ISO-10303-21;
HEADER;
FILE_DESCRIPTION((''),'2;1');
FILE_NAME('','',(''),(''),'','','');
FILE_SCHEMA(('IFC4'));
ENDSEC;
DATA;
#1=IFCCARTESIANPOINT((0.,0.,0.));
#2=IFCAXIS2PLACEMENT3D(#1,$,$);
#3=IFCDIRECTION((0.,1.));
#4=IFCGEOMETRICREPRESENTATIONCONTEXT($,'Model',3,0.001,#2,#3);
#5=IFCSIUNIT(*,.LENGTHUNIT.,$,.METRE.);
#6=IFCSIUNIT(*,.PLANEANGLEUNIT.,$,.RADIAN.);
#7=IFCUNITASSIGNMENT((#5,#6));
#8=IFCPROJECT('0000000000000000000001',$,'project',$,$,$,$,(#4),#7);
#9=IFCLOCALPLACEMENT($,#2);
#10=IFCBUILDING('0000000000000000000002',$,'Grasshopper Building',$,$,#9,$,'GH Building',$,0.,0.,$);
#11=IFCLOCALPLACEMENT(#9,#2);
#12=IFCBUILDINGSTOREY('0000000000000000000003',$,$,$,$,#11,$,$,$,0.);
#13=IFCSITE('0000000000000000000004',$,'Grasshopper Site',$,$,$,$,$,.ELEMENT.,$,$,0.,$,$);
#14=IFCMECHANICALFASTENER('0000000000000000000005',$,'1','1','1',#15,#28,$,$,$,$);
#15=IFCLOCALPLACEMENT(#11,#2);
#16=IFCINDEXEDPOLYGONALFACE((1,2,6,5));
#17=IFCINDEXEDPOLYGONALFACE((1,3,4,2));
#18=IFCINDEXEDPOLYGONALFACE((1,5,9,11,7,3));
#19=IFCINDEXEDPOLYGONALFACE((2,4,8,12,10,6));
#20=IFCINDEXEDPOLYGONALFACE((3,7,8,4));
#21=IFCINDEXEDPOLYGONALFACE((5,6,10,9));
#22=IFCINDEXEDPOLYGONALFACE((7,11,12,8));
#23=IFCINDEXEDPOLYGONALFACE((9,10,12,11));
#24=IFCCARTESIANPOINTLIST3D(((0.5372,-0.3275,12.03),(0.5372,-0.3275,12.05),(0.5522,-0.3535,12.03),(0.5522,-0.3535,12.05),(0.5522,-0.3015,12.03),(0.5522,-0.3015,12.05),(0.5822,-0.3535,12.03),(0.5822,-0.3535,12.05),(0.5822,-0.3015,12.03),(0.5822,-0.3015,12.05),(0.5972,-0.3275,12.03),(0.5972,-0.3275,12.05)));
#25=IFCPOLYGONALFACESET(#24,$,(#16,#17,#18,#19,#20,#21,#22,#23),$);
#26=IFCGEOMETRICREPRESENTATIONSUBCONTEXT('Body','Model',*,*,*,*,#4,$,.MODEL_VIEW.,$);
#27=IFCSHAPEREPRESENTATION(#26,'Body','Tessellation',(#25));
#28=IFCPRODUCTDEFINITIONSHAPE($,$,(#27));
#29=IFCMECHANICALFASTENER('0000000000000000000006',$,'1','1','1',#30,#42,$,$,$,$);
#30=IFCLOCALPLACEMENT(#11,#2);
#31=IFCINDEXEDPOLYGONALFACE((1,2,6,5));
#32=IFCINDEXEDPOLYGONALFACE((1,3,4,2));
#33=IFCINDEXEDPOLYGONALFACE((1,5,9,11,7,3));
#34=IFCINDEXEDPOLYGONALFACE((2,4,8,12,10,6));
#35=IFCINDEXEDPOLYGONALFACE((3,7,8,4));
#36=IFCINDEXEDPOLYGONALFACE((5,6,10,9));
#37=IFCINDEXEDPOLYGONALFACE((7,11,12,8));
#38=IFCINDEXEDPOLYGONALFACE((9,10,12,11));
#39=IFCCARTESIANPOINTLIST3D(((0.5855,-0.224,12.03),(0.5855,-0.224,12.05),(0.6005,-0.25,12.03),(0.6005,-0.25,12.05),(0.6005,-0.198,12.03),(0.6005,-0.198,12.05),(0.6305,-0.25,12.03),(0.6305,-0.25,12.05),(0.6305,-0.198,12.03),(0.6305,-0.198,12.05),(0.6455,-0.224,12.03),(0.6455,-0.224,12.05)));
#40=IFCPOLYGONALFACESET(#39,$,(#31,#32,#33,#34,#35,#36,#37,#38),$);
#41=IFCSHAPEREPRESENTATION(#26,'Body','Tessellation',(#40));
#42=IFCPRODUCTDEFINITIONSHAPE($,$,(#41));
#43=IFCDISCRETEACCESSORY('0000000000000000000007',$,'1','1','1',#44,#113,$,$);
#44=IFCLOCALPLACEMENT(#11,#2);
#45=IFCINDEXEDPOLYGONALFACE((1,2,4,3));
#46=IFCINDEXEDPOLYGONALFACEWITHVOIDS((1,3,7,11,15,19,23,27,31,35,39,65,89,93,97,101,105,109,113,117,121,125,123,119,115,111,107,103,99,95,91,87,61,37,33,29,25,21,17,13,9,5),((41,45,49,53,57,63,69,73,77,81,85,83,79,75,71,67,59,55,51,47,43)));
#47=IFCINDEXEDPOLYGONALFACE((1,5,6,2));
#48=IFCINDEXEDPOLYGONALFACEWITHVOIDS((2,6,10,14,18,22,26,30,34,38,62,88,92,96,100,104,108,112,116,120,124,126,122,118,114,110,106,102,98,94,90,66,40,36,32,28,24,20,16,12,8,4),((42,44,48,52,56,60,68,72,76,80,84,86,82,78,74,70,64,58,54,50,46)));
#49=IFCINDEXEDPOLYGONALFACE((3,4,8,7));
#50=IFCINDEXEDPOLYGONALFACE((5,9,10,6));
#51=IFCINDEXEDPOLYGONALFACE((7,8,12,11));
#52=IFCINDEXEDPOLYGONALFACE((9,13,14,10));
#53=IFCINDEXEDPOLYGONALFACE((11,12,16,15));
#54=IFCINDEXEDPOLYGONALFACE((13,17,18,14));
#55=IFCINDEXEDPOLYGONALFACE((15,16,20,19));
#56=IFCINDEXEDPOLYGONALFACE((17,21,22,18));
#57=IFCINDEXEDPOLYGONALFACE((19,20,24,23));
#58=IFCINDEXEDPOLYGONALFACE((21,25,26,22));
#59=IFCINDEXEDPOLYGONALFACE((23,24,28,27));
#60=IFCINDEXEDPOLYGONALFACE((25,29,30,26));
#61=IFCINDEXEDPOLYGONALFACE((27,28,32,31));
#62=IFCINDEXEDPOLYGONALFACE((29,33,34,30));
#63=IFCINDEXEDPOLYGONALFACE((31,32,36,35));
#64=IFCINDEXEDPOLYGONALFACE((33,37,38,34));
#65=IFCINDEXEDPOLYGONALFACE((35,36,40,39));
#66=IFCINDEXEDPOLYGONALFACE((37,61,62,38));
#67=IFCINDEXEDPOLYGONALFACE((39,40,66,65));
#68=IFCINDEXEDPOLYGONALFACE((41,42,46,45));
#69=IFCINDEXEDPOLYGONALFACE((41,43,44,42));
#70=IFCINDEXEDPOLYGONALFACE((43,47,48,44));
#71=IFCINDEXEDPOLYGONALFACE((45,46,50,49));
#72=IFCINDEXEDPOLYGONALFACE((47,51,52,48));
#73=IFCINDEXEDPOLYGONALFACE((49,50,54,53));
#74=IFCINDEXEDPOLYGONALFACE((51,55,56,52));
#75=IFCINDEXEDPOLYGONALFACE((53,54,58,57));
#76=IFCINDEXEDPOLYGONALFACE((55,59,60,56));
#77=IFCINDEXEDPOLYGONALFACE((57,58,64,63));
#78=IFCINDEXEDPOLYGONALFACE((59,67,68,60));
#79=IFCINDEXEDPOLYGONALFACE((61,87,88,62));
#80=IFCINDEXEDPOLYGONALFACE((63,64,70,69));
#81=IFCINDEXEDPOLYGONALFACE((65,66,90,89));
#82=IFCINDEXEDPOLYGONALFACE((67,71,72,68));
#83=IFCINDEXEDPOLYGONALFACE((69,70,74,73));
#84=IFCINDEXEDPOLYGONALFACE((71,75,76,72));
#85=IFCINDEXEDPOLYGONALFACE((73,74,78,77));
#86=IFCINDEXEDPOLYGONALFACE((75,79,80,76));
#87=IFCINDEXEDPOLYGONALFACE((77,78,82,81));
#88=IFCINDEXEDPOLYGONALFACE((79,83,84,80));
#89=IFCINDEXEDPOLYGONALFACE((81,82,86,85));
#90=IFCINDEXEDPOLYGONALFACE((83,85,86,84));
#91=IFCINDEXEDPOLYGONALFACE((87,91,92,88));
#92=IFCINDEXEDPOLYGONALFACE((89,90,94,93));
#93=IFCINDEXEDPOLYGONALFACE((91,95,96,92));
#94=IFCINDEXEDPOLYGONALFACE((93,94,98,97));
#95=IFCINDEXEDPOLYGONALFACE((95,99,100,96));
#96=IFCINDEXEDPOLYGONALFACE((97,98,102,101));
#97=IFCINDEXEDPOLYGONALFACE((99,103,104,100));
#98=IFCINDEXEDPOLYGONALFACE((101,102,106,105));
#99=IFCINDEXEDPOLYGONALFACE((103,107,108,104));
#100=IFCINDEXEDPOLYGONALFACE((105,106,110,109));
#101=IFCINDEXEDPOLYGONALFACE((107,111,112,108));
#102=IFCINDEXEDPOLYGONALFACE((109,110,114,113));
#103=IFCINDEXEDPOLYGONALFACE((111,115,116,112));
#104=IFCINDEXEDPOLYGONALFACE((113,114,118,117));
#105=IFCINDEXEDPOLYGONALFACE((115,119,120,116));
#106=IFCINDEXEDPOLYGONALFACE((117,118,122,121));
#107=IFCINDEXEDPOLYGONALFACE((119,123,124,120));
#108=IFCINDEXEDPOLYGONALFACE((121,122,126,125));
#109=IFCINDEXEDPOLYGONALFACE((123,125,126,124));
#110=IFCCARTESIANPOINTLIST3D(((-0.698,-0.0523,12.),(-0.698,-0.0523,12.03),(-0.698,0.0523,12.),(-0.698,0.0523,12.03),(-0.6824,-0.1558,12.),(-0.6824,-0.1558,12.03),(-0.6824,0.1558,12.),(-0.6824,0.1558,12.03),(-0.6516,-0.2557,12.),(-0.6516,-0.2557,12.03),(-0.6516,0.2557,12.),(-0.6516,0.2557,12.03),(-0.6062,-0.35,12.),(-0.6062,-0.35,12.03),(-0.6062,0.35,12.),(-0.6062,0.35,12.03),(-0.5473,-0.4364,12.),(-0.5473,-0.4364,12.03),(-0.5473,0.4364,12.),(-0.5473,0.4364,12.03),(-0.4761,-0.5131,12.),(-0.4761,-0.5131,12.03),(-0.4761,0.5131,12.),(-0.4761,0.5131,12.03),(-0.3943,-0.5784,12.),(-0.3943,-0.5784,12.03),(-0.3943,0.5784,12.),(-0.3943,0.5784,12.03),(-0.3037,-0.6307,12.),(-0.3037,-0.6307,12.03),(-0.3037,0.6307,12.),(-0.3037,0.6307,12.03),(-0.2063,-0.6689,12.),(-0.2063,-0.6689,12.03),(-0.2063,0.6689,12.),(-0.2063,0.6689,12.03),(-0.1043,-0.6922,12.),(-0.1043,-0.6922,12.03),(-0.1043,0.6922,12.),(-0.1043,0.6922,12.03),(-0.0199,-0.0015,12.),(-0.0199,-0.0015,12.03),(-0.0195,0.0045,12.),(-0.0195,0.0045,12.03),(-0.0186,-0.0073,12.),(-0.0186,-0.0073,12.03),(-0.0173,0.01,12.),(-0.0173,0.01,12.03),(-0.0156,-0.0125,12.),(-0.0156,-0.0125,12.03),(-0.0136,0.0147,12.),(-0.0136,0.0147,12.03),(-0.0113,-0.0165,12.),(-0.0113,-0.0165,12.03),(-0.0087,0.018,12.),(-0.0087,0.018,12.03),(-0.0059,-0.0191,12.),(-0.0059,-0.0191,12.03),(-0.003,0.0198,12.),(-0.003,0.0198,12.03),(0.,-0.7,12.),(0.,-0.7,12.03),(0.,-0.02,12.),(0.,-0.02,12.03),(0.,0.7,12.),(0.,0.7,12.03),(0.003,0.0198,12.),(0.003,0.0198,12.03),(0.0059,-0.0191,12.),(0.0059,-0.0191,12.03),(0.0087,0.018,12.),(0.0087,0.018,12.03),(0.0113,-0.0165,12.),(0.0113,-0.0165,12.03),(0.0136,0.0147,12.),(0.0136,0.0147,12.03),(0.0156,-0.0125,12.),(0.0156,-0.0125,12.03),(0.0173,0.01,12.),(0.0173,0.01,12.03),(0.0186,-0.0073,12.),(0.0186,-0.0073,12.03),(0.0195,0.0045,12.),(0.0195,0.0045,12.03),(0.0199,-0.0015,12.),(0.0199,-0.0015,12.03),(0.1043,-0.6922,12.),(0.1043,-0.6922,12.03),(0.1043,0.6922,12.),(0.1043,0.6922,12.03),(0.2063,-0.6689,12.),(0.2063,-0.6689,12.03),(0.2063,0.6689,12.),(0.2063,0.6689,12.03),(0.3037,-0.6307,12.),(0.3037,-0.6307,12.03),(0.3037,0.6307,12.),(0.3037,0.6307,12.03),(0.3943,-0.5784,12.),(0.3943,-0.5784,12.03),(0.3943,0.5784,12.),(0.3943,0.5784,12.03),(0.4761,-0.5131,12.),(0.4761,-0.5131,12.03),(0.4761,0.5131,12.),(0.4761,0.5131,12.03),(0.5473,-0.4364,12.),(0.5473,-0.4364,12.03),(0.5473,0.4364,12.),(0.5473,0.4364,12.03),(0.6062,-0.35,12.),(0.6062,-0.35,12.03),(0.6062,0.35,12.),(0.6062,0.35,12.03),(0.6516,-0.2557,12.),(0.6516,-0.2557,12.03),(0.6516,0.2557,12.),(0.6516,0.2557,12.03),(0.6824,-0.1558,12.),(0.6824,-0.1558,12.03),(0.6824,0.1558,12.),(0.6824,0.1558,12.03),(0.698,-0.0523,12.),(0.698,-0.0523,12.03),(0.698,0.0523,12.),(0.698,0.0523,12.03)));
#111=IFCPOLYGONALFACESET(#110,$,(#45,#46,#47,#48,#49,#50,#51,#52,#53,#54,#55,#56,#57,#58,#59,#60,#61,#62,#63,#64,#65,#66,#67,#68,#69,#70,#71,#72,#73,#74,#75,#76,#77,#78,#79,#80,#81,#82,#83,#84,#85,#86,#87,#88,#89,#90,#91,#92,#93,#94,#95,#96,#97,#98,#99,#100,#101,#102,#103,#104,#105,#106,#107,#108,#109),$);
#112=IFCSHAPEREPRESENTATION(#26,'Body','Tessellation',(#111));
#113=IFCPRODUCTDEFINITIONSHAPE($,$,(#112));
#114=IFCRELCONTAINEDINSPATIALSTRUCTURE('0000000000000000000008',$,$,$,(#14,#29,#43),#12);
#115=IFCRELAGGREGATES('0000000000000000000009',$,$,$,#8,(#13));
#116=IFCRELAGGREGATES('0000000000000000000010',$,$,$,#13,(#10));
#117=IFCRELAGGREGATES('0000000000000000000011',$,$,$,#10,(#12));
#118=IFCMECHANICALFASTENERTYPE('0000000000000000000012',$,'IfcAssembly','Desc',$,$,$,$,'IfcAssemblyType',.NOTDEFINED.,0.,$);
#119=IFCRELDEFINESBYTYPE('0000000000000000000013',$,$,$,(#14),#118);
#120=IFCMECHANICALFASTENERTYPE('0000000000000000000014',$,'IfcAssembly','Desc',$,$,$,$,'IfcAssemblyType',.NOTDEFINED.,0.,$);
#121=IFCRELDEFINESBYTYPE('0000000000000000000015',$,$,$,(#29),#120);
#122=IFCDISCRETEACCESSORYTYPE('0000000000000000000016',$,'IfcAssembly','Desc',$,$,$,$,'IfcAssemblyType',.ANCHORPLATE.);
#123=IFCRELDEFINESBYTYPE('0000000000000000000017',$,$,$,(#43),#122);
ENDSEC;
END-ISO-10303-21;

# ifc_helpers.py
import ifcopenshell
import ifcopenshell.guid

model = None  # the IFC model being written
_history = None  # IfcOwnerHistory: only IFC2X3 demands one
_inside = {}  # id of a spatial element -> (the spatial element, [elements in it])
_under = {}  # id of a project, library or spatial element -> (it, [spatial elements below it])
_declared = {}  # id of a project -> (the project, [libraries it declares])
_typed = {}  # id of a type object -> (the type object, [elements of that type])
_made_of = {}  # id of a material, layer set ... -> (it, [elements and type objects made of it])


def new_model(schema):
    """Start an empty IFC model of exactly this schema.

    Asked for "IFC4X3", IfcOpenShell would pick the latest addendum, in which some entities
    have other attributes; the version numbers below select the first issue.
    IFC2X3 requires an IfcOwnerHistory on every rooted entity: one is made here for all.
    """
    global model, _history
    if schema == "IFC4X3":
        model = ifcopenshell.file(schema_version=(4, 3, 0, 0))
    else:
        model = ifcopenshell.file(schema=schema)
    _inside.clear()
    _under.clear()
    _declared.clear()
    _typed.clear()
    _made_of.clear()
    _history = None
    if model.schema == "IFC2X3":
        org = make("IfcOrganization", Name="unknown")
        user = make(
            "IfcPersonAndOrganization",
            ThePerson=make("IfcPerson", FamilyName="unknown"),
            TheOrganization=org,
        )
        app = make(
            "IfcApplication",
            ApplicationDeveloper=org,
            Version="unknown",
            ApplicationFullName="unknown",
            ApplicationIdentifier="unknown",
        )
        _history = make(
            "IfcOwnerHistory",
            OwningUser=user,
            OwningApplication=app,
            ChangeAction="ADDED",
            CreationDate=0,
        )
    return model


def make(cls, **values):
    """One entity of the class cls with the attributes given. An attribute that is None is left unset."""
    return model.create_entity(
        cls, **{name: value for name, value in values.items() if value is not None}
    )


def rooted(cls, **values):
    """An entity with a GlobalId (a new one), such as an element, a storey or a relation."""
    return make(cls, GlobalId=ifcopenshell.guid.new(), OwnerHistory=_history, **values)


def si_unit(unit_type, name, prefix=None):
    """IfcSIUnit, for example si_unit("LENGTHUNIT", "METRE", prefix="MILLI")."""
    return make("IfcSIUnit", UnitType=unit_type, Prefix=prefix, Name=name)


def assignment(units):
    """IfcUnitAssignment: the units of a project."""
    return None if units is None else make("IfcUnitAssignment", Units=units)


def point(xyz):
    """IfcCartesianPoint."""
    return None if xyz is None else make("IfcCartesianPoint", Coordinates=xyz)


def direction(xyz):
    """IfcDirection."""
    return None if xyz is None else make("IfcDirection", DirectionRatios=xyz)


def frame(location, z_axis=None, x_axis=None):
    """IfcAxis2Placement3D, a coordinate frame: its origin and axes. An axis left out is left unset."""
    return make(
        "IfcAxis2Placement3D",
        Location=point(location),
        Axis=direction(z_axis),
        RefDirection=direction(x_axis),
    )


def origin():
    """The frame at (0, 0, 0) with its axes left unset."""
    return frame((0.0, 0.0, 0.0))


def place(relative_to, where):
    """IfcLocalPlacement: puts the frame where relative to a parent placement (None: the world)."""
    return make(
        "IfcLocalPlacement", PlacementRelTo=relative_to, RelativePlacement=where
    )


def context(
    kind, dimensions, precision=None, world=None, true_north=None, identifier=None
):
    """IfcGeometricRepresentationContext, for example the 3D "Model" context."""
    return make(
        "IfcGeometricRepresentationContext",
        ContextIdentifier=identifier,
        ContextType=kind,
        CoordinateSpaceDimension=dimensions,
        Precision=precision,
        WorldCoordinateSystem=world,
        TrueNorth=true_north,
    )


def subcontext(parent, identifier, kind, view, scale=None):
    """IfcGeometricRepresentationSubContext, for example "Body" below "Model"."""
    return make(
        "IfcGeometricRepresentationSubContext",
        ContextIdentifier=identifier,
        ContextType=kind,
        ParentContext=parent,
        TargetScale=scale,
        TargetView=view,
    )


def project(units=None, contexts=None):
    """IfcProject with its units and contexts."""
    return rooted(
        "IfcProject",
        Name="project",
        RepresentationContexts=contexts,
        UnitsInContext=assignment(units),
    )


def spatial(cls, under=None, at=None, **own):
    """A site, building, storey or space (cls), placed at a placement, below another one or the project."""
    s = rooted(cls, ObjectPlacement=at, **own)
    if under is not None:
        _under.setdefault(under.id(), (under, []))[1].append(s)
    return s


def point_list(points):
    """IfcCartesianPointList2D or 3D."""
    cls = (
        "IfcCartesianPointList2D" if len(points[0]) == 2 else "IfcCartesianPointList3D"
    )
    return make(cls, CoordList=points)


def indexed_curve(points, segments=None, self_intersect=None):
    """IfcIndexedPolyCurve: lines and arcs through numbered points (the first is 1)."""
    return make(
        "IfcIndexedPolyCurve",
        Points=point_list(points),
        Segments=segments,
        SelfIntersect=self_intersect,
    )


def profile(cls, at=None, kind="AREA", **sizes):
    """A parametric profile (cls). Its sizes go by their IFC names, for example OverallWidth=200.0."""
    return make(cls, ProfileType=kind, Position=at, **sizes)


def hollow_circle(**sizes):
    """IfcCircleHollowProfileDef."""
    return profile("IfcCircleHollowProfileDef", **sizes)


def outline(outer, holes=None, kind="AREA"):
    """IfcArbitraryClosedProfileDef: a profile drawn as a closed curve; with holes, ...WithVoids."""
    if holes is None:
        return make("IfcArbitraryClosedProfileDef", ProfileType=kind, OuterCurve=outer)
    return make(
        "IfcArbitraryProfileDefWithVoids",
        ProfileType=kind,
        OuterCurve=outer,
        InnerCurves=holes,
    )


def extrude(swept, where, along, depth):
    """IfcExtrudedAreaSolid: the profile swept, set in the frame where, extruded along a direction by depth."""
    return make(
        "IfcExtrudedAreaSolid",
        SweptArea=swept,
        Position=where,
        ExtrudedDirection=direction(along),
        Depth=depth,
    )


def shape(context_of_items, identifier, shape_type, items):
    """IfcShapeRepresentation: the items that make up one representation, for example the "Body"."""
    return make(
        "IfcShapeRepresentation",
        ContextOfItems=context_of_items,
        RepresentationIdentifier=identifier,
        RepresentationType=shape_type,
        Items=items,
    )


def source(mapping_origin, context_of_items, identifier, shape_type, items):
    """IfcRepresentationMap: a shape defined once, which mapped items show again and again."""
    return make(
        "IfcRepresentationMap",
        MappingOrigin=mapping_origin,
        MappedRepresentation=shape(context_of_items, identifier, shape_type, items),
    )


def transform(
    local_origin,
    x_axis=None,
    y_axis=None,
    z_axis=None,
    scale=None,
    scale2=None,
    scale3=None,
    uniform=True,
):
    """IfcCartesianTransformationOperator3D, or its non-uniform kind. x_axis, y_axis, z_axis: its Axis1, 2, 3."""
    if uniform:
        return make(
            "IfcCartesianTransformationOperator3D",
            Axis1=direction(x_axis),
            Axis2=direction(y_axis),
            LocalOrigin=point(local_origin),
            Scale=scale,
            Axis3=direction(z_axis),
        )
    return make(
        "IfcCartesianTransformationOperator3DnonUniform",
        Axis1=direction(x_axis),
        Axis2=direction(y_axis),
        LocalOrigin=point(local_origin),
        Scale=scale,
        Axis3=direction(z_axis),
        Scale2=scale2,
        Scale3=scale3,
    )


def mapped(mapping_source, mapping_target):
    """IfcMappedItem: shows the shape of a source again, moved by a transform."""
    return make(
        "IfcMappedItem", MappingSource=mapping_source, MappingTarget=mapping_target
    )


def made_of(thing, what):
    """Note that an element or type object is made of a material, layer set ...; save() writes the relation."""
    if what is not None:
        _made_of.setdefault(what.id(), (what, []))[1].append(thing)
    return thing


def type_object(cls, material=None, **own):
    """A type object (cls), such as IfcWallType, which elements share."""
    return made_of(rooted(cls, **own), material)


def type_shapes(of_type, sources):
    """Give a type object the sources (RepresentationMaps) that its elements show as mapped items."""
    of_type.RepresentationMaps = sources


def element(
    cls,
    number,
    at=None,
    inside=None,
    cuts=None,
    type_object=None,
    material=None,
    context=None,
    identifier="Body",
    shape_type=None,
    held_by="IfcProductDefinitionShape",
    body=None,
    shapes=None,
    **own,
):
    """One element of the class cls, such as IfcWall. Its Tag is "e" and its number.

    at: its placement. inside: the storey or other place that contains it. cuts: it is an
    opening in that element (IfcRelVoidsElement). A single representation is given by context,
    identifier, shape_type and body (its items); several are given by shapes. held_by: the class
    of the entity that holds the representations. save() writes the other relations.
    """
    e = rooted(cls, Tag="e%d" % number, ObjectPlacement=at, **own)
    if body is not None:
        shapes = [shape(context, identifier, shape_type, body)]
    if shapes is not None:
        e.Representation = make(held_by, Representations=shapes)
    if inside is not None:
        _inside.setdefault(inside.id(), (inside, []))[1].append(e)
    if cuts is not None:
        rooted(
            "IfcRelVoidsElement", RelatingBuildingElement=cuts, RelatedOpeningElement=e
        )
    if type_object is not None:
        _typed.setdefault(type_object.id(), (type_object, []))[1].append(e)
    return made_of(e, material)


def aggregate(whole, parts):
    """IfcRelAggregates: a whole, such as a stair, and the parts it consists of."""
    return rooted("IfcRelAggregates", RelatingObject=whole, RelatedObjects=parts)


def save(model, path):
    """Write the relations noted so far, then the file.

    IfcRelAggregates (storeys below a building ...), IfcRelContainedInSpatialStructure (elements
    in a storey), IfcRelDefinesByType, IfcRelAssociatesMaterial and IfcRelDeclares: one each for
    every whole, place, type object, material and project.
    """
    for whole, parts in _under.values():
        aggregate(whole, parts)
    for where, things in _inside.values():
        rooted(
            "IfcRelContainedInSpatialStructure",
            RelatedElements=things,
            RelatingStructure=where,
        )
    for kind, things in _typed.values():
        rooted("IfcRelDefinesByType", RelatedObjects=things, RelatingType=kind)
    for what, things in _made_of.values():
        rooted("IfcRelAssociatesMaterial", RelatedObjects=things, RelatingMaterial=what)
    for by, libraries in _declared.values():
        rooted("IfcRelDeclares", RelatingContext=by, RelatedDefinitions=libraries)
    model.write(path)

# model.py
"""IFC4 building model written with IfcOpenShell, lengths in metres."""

from ifc_helpers import new_model, si_unit, direction, frame, origin, place, context, subcontext, project, spatial, indexed_curve, hollow_circle, outline, extrude, source, transform, mapped, type_object, type_shapes, element, save


model = new_model("IFC4")

# Units and contexts
model_context = context("Model", 3, precision=0.001, world=origin(), true_north=direction((0.0, 1.0)))
body_context = subcontext(model_context, "Body", "Model", "MODEL_VIEW")
ifc_project = project(units=[si_unit("LENGTHUNIT", "METRE"), si_unit("PLANEANGLEUNIT", "RADIAN")], contexts=[model_context])

# Site, building, storey
site = spatial("IfcSite", under=ifc_project, Name="Grasshopper Site", CompositionType="ELEMENT", RefElevation=0.0)
building_placement = place(None, origin())
building = spatial("IfcBuilding", under=site, at=building_placement, Name="Grasshopper Building", LongName="GH Building", ElevationOfRefHeight=0.0, ElevationOfTerrain=0.0)
storey_placement = place(building_placement, origin())
storey = spatial("IfcBuildingStorey", under=building, at=storey_placement, Elevation=0.0)

# Mechanical fasteners
mechanical_fastener_type_1 = type_object("IfcMechanicalFastenerType", Name="IfcAssembly", Description="Desc", ElementType="IfcAssemblyType", NominalDiameter=0.0)
shared_shape_1 = source(origin(), body_context, "Body", "SweptSolid", [
    extrude(outline(indexed_curve([(0.03, 0.0), (0.015, 0.026), (-0.015, 0.026), (-0.03, 0.0), (-0.015, -0.026), (0.015, -0.026), (0.03, 0.0)])), frame((0.5672, -0.3275, 12.03)), (0.0, 0.0, 1.0), 0.02),
])
type_shapes(mechanical_fastener_type_1, [shared_shape_1])
mechanical_fastener_1_placement = place(storey_placement, origin())
element("IfcMechanicalFastener", 1, at=mechanical_fastener_1_placement, inside=storey, type_object=mechanical_fastener_type_1, Name="1", Description="1", ObjectType="1", context=body_context, shape_type="MappedRepresentation", body=[
    mapped(shared_shape_1, transform((0.0, 0.0, 0.0), scale=1.0)),
])
mechanical_fastener_type_2 = type_object("IfcMechanicalFastenerType", Name="IfcAssembly", Description="Desc", ElementType="IfcAssemblyType", NominalDiameter=0.0)
shared_shape_2 = source(origin(), body_context, "Body", "SweptSolid", [
    extrude(outline(indexed_curve([(0.03, 0.0), (0.015, 0.026), (-0.015, 0.026), (-0.03, 0.0), (-0.015, -0.026), (0.015, -0.026), (0.03, 0.0)])), frame((0.6155, -0.224, 12.03)), (0.0, 0.0, 1.0), 0.02),
])
type_shapes(mechanical_fastener_type_2, [shared_shape_2])
mechanical_fastener_2_placement = place(storey_placement, origin())
element("IfcMechanicalFastener", 2, at=mechanical_fastener_2_placement, inside=storey, type_object=mechanical_fastener_type_2, Name="1", Description="1", ObjectType="1", context=body_context, shape_type="MappedRepresentation", body=[
    mapped(shared_shape_2, transform((0.0, 0.0, 0.0), scale=1.0)),
])

# Discrete accessory
discrete_accessory_type = type_object("IfcDiscreteAccessoryType", Name="IfcAssembly", Description="Desc", ElementType="IfcAssemblyType", PredefinedType="ANCHORPLATE")
shared_shape_3 = source(origin(), body_context, "Body", "SweptSolid", [
    extrude(hollow_circle(Radius=0.7, WallThickness=0.68), frame((0.0, 0.0, 12.0), z_axis=(0.0, 0.0, 1.0), x_axis=(0.0, -1.0, 0.0)), (0.0, 0.0, 1.0), 0.03),
])
type_shapes(discrete_accessory_type, [shared_shape_3])
discrete_accessory_placement = place(storey_placement, origin())
element("IfcDiscreteAccessory", 3, at=discrete_accessory_placement, inside=storey, type_object=discrete_accessory_type, Name="1", Description="1", ObjectType="1", context=body_context, shape_type="MappedRepresentation", body=[
    mapped(shared_shape_3, transform((0.0, 0.0, 0.0), scale=1.0)),
])

save(model, "model.ifc")
